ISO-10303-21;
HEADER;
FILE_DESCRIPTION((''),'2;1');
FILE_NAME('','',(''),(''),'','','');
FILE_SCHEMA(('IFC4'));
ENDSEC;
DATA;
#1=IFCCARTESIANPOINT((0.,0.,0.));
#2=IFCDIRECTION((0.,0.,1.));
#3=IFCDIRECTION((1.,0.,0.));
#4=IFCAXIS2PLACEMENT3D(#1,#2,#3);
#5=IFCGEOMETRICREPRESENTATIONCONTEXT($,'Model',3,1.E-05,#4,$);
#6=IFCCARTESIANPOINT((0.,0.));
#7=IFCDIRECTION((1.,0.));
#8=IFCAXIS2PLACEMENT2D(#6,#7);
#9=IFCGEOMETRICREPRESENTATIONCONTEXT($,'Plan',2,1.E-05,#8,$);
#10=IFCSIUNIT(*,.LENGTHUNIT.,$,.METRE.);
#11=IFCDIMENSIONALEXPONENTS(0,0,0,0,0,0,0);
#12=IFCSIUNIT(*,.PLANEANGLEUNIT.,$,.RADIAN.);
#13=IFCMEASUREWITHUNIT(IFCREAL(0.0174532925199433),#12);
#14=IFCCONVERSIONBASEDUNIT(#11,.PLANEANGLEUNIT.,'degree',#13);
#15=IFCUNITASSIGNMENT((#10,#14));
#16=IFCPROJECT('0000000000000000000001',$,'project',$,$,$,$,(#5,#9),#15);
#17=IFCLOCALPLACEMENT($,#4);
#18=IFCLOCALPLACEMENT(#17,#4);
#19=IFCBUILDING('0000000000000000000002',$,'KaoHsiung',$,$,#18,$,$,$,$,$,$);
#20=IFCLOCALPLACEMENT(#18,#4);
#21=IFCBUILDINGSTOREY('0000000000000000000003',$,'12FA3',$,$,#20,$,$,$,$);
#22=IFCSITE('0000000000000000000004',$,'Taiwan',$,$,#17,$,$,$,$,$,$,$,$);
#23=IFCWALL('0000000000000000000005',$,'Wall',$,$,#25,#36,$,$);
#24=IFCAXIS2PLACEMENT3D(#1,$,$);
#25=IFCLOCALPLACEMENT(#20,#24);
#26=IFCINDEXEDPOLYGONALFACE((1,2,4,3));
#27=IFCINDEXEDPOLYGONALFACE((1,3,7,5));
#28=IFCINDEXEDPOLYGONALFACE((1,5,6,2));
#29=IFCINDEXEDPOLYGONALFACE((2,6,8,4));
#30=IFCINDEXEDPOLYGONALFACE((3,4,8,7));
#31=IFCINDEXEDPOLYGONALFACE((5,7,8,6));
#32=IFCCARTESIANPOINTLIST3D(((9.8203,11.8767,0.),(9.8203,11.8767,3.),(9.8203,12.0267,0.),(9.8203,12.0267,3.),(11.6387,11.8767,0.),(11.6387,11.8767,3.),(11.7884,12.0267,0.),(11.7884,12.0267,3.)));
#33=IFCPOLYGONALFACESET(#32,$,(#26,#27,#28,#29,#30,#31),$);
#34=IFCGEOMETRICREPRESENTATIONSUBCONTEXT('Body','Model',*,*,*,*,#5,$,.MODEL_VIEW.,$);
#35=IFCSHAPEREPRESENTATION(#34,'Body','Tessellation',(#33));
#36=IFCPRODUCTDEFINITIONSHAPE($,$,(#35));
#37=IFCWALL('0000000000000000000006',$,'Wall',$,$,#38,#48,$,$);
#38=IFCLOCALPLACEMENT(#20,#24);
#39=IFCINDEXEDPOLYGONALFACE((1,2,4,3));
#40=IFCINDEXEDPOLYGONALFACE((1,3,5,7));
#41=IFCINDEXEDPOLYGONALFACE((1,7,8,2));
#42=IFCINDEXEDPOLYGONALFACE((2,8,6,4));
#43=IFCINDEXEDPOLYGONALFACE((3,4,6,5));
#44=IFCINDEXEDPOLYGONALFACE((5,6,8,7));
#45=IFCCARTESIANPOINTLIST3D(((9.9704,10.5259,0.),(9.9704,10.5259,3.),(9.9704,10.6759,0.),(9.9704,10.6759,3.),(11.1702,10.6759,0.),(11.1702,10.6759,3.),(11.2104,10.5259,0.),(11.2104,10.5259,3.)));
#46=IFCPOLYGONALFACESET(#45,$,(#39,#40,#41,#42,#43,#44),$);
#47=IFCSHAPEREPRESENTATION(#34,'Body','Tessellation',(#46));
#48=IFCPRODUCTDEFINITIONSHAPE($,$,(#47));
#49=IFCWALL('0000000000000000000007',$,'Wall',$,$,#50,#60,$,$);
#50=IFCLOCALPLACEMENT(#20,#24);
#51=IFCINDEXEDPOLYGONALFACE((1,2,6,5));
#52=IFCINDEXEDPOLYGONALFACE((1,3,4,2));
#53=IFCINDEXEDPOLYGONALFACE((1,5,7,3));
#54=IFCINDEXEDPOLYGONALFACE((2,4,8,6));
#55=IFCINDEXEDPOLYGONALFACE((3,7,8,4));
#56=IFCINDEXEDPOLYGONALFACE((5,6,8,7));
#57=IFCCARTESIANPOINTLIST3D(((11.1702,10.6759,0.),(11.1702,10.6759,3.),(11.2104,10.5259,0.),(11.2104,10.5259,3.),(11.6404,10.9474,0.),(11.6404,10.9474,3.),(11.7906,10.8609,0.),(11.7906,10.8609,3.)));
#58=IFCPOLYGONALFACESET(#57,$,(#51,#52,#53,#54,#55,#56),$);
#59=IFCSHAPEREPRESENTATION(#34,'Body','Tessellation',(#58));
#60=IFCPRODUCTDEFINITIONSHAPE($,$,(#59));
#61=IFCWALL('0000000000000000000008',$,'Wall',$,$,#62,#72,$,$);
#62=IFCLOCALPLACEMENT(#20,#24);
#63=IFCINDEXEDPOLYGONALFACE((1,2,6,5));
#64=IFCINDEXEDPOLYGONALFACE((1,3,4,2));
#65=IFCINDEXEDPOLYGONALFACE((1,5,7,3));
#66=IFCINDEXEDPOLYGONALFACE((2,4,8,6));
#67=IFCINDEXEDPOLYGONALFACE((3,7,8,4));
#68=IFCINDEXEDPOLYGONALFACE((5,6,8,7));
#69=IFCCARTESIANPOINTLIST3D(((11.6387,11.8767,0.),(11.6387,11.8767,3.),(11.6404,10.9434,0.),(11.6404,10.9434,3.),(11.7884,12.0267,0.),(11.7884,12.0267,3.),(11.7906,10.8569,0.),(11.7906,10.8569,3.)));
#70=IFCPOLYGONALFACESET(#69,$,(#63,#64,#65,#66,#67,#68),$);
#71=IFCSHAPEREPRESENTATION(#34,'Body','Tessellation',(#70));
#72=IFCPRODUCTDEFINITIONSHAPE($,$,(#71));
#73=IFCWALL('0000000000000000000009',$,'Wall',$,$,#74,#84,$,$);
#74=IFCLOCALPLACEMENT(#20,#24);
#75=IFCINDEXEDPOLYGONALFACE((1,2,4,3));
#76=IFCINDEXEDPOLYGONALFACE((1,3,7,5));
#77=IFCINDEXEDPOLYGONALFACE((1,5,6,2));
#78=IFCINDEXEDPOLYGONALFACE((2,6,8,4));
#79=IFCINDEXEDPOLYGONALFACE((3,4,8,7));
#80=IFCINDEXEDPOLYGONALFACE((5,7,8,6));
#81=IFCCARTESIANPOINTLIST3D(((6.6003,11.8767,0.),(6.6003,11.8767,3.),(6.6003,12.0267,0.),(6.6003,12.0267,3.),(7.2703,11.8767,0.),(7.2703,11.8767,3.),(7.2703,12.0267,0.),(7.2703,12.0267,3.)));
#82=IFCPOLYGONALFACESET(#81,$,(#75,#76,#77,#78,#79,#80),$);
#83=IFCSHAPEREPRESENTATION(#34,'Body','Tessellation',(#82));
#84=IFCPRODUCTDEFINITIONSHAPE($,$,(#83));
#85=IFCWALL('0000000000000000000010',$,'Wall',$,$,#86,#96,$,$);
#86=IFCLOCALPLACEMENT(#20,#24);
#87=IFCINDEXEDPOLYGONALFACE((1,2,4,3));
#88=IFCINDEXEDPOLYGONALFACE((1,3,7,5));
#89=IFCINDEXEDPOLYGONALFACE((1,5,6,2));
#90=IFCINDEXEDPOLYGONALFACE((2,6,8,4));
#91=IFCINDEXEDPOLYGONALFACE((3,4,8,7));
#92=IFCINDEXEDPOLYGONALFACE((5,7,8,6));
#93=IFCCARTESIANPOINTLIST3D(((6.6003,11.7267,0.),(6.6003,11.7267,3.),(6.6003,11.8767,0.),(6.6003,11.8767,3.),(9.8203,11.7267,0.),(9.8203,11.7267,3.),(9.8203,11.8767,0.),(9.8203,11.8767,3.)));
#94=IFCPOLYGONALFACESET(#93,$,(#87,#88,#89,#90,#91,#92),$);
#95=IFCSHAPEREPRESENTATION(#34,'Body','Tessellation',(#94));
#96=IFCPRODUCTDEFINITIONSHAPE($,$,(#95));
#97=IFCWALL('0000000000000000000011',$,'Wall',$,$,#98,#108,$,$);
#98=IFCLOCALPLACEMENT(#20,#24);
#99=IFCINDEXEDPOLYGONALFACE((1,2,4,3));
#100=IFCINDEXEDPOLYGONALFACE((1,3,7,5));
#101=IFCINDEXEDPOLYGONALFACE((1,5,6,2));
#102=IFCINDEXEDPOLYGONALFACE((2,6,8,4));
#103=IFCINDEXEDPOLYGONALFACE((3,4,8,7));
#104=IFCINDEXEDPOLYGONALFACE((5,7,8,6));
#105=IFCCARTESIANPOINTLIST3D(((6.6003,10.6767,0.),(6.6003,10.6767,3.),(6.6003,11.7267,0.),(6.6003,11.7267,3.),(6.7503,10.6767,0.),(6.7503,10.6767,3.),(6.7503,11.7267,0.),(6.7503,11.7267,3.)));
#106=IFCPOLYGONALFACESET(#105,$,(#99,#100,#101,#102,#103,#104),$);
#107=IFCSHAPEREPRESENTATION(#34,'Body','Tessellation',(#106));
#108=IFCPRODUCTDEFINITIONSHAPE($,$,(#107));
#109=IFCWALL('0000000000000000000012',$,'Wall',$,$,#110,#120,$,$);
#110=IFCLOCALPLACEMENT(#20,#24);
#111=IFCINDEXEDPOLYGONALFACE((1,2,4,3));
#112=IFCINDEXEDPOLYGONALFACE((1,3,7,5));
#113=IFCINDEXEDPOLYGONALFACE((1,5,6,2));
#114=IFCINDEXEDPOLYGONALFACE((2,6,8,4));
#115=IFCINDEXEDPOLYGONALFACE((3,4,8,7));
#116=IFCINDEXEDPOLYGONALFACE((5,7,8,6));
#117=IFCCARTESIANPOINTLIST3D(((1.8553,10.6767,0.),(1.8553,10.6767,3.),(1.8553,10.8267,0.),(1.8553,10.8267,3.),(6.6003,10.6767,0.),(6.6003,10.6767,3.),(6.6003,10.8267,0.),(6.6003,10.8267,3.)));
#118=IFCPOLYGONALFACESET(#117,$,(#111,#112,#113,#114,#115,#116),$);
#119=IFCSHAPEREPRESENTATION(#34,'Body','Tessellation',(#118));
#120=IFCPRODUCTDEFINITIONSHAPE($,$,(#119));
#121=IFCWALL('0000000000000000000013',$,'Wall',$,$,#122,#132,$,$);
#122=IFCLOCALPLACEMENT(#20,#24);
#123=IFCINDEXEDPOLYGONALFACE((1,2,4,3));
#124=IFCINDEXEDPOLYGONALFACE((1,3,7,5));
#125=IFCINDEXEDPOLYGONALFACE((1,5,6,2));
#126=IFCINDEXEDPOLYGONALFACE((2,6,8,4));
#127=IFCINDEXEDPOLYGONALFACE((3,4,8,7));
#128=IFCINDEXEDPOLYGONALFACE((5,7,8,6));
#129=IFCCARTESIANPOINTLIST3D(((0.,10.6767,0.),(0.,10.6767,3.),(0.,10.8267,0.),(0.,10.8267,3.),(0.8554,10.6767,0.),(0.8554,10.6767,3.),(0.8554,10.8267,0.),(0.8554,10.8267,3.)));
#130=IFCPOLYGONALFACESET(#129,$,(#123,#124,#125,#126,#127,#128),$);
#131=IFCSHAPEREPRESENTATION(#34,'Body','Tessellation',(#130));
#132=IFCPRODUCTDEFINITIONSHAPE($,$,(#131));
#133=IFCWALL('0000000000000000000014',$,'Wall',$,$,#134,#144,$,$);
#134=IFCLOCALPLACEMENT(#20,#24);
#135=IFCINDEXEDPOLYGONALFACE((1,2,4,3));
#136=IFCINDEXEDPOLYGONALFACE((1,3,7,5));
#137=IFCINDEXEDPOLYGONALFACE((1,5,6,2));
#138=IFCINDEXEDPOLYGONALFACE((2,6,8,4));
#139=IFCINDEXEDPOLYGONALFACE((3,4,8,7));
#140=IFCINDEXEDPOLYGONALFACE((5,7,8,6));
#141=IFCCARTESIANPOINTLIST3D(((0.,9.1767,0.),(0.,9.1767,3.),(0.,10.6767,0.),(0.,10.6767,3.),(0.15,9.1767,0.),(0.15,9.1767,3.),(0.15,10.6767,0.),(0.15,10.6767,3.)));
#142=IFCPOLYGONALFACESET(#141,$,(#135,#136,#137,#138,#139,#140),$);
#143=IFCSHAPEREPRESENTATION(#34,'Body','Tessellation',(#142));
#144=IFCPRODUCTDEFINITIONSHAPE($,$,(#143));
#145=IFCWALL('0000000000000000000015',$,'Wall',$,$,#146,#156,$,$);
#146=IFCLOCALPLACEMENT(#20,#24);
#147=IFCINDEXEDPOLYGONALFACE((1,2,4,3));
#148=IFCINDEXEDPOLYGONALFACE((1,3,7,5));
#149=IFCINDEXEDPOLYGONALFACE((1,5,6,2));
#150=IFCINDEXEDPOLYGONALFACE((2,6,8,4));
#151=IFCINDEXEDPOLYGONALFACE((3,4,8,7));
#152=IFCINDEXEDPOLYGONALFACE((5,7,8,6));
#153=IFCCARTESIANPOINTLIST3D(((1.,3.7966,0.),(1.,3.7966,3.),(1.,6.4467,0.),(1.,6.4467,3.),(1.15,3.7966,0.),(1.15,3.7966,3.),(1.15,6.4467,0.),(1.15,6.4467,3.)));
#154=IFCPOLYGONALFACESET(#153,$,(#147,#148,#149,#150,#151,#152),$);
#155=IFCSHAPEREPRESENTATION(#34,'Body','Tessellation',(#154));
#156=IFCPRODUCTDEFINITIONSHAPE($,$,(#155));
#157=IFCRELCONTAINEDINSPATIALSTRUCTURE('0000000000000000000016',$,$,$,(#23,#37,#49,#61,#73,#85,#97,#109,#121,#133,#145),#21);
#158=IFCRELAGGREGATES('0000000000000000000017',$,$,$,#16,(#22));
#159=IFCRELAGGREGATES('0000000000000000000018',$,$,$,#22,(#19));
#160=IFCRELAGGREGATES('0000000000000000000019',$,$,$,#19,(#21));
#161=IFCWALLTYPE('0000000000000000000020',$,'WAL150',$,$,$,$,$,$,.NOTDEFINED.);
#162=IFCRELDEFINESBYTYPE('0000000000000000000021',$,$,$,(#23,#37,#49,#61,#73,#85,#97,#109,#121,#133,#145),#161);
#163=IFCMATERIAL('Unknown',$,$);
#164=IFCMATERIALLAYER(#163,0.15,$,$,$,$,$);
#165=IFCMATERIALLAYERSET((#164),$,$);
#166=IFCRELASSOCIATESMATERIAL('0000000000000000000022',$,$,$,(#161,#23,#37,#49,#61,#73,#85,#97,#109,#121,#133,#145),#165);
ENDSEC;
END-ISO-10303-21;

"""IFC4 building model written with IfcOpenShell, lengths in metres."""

from ifc_helpers import new_model, entity, si_unit, converted_unit, frame, origin_with_axes, origin_2d_with_axis, place, context, subcontext, project, spatial, line, indexed_curve, outline, extrude, material, layer, layer_set, layer_usage, type_object, element, save


model = new_model("IFC4")

# Units and contexts
model_context = context("Model", 3, precision=1e-05, world=origin_with_axes())
plan_context = context("Plan", 2, precision=1e-05, world=origin_2d_with_axis())
body_context = subcontext(model_context, "Body", "Model", "MODEL_VIEW")
ifc_project = project(units=[si_unit("LENGTHUNIT", "METRE"), converted_unit("PLANEANGLEUNIT", "degree", entity("IfcReal", 0.0174532925199433), si_unit("PLANEANGLEUNIT", "RADIAN"), dimensions=[0, 0, 0, 0, 0, 0, 0])], contexts=[model_context, plan_context])

# Site, building, storey
site_placement = place(None, origin_with_axes())
site = spatial("IfcSite", under=ifc_project, at=site_placement, Name="Taiwan")
building_placement = place(site_placement, origin_with_axes())
building = spatial("IfcBuilding", under=site, at=building_placement, Name="KaoHsiung")
storey_placement = place(building_placement, origin_with_axes())
storey = spatial("IfcBuildingStorey", under=building, at=storey_placement, Name="12FA3")

# Shared definitions
ifc_material = material(Name="Unknown")

# Walls
ifc_layer_1 = layer(ifc_material, 0.15)
ifc_layer_set_1 = layer_set([ifc_layer_1])
wall_type_1 = type_object("IfcWallType", Name="WAL150", PredefinedType="NOTDEFINED", material=ifc_layer_set_1)
ifc_layer_usage_1 = layer_usage(ifc_layer_set_1, "AXIS2", "POSITIVE", 0.0)
wall_1_placement = place(storey_placement, frame((11.7884, 12.0267, 0.0), z_axis=(0.0, 0.0, 1.0), x_axis=(-1.0, 0.0, 0.0)))
element("IfcWall", 1, at=wall_1_placement, inside=storey, type_object=wall_type_1, material=ifc_layer_usage_1, Name="Wall", context=body_context, shape_type="SweptSolid", body=[
    extrude(outline(indexed_curve([(0.0, 0.0), (0.1497, 0.15), (1.9681, 0.15), (1.9681, 0.0)], segments=[line(1, 2, 3, 4, 1)])), origin_with_axes(), (0.0, 0.0, 1.0), 3.0),
])
ifc_layer_usage_2 = layer_usage(ifc_layer_set_1, "AXIS2", "POSITIVE", 0.0)
wall_2_placement = place(storey_placement, frame((9.9704, 10.5259, 0.0), z_axis=(0.0, 0.0, 1.0), x_axis=(1.0, 0.0, 0.0)))
element("IfcWall", 2, at=wall_2_placement, inside=storey, type_object=wall_type_1, material=ifc_layer_usage_2, Name="Wall", context=body_context, shape_type="SweptSolid", body=[
    extrude(outline(indexed_curve([(0.0, 0.0), (0.0, 0.15), (1.1998, 0.15), (1.24, 0.0)], segments=[line(1, 2, 3, 4, 1)])), origin_with_axes(), (0.0, 0.0, 1.0), 3.0),
])
ifc_layer_usage_3 = layer_usage(ifc_layer_set_1, "AXIS2", "POSITIVE", 0.0)
wall_3_placement = place(storey_placement, frame((11.2104, 10.5259, 0.0), z_axis=(0.0, 0.0, 1.0), x_axis=(0.866026, 0.5, 0.0)))
element("IfcWall", 3, at=wall_3_placement, inside=storey, type_object=wall_type_1, material=ifc_layer_usage_3, Name="Wall", context=body_context, shape_type="SweptSolid", body=[
    extrude(outline(indexed_curve([(0.0, 0.0), (0.0402, 0.15), (0.5832, 0.15), (0.67, 0.0)], segments=[line(1, 2, 3, 4, 1)])), origin_with_axes(), (0.0, 0.0, 1.0), 3.0),
])
ifc_layer_usage_4 = layer_usage(ifc_layer_set_1, "AXIS2", "POSITIVE", 0.0)
wall_4_placement = place(storey_placement, frame((11.7906, 10.8569, 0.0), z_axis=(0.0, 0.0, 1.0), x_axis=(-0.001882, 0.999998, 0.0)))
element("IfcWall", 4, at=wall_4_placement, inside=storey, type_object=wall_type_1, material=ifc_layer_usage_4, Name="Wall", context=body_context, shape_type="SweptSolid", body=[
    extrude(outline(indexed_curve([(0.0, 0.0), (0.0868, 0.15), (1.02, 0.15), (1.1698, 0.0)], segments=[line(1, 2, 3, 4, 1)])), origin_with_axes(), (0.0, 0.0, 1.0), 3.0),
])
ifc_layer_usage_5 = layer_usage(ifc_layer_set_1, "AXIS2", "POSITIVE", 0.0)
wall_5_placement = place(storey_placement, frame((7.2703, 12.0267, 0.0), z_axis=(0.0, 0.0, 1.0), x_axis=(-1.0, 0.0, 0.0)))
element("IfcWall", 5, at=wall_5_placement, inside=storey, type_object=wall_type_1, material=ifc_layer_usage_5, Name="Wall", context=body_context, shape_type="SweptSolid", body=[
    extrude(outline(indexed_curve([(0.0, 0.0), (0.0, 0.15), (0.67, 0.15), (0.67, 0.0)], segments=[line(1, 2, 3, 4, 1)])), origin_with_axes(), (0.0, 0.0, 1.0), 3.0),
])
ifc_layer_usage_6 = layer_usage(ifc_layer_set_1, "AXIS2", "POSITIVE", 0.0)
wall_6_placement = place(storey_placement, frame((9.8203, 11.8767, 0.0), z_axis=(0.0, 0.0, 1.0), x_axis=(-1.0, 0.0, 0.0)))
element("IfcWall", 6, at=wall_6_placement, inside=storey, type_object=wall_type_1, material=ifc_layer_usage_6, Name="Wall", context=body_context, shape_type="SweptSolid", body=[
    extrude(outline(indexed_curve([(0.0, 0.0), (0.0, 0.15), (3.22, 0.15), (3.22, 0.0)], segments=[line(1, 2, 3, 4, 1)])), origin_with_axes(), (0.0, 0.0, 1.0), 3.0),
])
ifc_layer_usage_7 = layer_usage(ifc_layer_set_1, "AXIS2", "POSITIVE", 0.0)
wall_7_placement = place(storey_placement, frame((6.6003, 11.7267, 0.0), z_axis=(0.0, 0.0, 1.0), x_axis=(0.0, -1.0, 0.0)))
element("IfcWall", 7, at=wall_7_placement, inside=storey, type_object=wall_type_1, material=ifc_layer_usage_7, Name="Wall", context=body_context, shape_type="SweptSolid", body=[
    extrude(outline(indexed_curve([(0.0, 0.0), (0.0, 0.15), (1.05, 0.15), (1.05, 0.0)], segments=[line(1, 2, 3, 4, 1)])), origin_with_axes(), (0.0, 0.0, 1.0), 3.0),
])
ifc_layer_usage_8 = layer_usage(ifc_layer_set_1, "AXIS2", "POSITIVE", 0.0)
wall_8_placement = place(storey_placement, frame((6.6003, 10.8267, 0.0), z_axis=(0.0, 0.0, 1.0), x_axis=(-1.0, 0.0, 0.0)))
element("IfcWall", 8, at=wall_8_placement, inside=storey, type_object=wall_type_1, material=ifc_layer_usage_8, Name="Wall", context=body_context, shape_type="SweptSolid", body=[
    extrude(outline(indexed_curve([(0.0, 0.0), (0.0, 0.15), (4.745, 0.15), (4.745, 0.0)], segments=[line(1, 2, 3, 4, 1)])), origin_with_axes(), (0.0, 0.0, 1.0), 3.0),
])
ifc_layer_usage_9 = layer_usage(ifc_layer_set_1, "AXIS2", "POSITIVE", 0.0)
wall_9_placement = place(storey_placement, frame((0.8554, 10.8267, 0.0), z_axis=(0.0, 0.0, 1.0), x_axis=(-1.0, 0.0, 0.0)))
element("IfcWall", 9, at=wall_9_placement, inside=storey, type_object=wall_type_1, material=ifc_layer_usage_9, Name="Wall", context=body_context, shape_type="SweptSolid", body=[
    extrude(outline(indexed_curve([(0.0, 0.0), (0.0, 0.15), (0.8553, 0.15), (0.8553, 0.0)], segments=[line(1, 2, 3, 4, 1)])), origin_with_axes(), (0.0, 0.0, 1.0), 3.0),
])
ifc_layer_usage_10 = layer_usage(ifc_layer_set_1, "AXIS2", "POSITIVE", 0.0)
wall_10_placement = place(storey_placement, frame((0.0, 10.6767, 0.0), z_axis=(0.0, 0.0, 1.0), x_axis=(0.0, -1.0, 0.0)))
element("IfcWall", 10, at=wall_10_placement, inside=storey, type_object=wall_type_1, material=ifc_layer_usage_10, Name="Wall", context=body_context, shape_type="SweptSolid", body=[
    extrude(outline(indexed_curve([(0.0, 0.0), (0.0, 0.15), (1.5, 0.15), (1.5, 0.0)], segments=[line(1, 2, 3, 4, 1)])), origin_with_axes(), (0.0, 0.0, 1.0), 3.0),
])
ifc_layer_usage_11 = layer_usage(ifc_layer_set_1, "AXIS2", "POSITIVE", 0.0)
wall_11_placement = place(storey_placement, frame((1.0, 6.4467, 0.0), z_axis=(0.0, 0.0, 1.0), x_axis=(0.0, -1.0, 0.0)))
element("IfcWall", 11, at=wall_11_placement, inside=storey, type_object=wall_type_1, material=ifc_layer_usage_11, Name="Wall", context=body_context, shape_type="SweptSolid", body=[
    extrude(outline(indexed_curve([(0.0, 0.0), (0.0, 0.15), (2.6501, 0.15), (2.6501, 0.0)], segments=[line(1, 2, 3, 4, 1)])), origin_with_axes(), (0.0, 0.0, 1.0), 3.0),
])

save(model, "model.ifc")
